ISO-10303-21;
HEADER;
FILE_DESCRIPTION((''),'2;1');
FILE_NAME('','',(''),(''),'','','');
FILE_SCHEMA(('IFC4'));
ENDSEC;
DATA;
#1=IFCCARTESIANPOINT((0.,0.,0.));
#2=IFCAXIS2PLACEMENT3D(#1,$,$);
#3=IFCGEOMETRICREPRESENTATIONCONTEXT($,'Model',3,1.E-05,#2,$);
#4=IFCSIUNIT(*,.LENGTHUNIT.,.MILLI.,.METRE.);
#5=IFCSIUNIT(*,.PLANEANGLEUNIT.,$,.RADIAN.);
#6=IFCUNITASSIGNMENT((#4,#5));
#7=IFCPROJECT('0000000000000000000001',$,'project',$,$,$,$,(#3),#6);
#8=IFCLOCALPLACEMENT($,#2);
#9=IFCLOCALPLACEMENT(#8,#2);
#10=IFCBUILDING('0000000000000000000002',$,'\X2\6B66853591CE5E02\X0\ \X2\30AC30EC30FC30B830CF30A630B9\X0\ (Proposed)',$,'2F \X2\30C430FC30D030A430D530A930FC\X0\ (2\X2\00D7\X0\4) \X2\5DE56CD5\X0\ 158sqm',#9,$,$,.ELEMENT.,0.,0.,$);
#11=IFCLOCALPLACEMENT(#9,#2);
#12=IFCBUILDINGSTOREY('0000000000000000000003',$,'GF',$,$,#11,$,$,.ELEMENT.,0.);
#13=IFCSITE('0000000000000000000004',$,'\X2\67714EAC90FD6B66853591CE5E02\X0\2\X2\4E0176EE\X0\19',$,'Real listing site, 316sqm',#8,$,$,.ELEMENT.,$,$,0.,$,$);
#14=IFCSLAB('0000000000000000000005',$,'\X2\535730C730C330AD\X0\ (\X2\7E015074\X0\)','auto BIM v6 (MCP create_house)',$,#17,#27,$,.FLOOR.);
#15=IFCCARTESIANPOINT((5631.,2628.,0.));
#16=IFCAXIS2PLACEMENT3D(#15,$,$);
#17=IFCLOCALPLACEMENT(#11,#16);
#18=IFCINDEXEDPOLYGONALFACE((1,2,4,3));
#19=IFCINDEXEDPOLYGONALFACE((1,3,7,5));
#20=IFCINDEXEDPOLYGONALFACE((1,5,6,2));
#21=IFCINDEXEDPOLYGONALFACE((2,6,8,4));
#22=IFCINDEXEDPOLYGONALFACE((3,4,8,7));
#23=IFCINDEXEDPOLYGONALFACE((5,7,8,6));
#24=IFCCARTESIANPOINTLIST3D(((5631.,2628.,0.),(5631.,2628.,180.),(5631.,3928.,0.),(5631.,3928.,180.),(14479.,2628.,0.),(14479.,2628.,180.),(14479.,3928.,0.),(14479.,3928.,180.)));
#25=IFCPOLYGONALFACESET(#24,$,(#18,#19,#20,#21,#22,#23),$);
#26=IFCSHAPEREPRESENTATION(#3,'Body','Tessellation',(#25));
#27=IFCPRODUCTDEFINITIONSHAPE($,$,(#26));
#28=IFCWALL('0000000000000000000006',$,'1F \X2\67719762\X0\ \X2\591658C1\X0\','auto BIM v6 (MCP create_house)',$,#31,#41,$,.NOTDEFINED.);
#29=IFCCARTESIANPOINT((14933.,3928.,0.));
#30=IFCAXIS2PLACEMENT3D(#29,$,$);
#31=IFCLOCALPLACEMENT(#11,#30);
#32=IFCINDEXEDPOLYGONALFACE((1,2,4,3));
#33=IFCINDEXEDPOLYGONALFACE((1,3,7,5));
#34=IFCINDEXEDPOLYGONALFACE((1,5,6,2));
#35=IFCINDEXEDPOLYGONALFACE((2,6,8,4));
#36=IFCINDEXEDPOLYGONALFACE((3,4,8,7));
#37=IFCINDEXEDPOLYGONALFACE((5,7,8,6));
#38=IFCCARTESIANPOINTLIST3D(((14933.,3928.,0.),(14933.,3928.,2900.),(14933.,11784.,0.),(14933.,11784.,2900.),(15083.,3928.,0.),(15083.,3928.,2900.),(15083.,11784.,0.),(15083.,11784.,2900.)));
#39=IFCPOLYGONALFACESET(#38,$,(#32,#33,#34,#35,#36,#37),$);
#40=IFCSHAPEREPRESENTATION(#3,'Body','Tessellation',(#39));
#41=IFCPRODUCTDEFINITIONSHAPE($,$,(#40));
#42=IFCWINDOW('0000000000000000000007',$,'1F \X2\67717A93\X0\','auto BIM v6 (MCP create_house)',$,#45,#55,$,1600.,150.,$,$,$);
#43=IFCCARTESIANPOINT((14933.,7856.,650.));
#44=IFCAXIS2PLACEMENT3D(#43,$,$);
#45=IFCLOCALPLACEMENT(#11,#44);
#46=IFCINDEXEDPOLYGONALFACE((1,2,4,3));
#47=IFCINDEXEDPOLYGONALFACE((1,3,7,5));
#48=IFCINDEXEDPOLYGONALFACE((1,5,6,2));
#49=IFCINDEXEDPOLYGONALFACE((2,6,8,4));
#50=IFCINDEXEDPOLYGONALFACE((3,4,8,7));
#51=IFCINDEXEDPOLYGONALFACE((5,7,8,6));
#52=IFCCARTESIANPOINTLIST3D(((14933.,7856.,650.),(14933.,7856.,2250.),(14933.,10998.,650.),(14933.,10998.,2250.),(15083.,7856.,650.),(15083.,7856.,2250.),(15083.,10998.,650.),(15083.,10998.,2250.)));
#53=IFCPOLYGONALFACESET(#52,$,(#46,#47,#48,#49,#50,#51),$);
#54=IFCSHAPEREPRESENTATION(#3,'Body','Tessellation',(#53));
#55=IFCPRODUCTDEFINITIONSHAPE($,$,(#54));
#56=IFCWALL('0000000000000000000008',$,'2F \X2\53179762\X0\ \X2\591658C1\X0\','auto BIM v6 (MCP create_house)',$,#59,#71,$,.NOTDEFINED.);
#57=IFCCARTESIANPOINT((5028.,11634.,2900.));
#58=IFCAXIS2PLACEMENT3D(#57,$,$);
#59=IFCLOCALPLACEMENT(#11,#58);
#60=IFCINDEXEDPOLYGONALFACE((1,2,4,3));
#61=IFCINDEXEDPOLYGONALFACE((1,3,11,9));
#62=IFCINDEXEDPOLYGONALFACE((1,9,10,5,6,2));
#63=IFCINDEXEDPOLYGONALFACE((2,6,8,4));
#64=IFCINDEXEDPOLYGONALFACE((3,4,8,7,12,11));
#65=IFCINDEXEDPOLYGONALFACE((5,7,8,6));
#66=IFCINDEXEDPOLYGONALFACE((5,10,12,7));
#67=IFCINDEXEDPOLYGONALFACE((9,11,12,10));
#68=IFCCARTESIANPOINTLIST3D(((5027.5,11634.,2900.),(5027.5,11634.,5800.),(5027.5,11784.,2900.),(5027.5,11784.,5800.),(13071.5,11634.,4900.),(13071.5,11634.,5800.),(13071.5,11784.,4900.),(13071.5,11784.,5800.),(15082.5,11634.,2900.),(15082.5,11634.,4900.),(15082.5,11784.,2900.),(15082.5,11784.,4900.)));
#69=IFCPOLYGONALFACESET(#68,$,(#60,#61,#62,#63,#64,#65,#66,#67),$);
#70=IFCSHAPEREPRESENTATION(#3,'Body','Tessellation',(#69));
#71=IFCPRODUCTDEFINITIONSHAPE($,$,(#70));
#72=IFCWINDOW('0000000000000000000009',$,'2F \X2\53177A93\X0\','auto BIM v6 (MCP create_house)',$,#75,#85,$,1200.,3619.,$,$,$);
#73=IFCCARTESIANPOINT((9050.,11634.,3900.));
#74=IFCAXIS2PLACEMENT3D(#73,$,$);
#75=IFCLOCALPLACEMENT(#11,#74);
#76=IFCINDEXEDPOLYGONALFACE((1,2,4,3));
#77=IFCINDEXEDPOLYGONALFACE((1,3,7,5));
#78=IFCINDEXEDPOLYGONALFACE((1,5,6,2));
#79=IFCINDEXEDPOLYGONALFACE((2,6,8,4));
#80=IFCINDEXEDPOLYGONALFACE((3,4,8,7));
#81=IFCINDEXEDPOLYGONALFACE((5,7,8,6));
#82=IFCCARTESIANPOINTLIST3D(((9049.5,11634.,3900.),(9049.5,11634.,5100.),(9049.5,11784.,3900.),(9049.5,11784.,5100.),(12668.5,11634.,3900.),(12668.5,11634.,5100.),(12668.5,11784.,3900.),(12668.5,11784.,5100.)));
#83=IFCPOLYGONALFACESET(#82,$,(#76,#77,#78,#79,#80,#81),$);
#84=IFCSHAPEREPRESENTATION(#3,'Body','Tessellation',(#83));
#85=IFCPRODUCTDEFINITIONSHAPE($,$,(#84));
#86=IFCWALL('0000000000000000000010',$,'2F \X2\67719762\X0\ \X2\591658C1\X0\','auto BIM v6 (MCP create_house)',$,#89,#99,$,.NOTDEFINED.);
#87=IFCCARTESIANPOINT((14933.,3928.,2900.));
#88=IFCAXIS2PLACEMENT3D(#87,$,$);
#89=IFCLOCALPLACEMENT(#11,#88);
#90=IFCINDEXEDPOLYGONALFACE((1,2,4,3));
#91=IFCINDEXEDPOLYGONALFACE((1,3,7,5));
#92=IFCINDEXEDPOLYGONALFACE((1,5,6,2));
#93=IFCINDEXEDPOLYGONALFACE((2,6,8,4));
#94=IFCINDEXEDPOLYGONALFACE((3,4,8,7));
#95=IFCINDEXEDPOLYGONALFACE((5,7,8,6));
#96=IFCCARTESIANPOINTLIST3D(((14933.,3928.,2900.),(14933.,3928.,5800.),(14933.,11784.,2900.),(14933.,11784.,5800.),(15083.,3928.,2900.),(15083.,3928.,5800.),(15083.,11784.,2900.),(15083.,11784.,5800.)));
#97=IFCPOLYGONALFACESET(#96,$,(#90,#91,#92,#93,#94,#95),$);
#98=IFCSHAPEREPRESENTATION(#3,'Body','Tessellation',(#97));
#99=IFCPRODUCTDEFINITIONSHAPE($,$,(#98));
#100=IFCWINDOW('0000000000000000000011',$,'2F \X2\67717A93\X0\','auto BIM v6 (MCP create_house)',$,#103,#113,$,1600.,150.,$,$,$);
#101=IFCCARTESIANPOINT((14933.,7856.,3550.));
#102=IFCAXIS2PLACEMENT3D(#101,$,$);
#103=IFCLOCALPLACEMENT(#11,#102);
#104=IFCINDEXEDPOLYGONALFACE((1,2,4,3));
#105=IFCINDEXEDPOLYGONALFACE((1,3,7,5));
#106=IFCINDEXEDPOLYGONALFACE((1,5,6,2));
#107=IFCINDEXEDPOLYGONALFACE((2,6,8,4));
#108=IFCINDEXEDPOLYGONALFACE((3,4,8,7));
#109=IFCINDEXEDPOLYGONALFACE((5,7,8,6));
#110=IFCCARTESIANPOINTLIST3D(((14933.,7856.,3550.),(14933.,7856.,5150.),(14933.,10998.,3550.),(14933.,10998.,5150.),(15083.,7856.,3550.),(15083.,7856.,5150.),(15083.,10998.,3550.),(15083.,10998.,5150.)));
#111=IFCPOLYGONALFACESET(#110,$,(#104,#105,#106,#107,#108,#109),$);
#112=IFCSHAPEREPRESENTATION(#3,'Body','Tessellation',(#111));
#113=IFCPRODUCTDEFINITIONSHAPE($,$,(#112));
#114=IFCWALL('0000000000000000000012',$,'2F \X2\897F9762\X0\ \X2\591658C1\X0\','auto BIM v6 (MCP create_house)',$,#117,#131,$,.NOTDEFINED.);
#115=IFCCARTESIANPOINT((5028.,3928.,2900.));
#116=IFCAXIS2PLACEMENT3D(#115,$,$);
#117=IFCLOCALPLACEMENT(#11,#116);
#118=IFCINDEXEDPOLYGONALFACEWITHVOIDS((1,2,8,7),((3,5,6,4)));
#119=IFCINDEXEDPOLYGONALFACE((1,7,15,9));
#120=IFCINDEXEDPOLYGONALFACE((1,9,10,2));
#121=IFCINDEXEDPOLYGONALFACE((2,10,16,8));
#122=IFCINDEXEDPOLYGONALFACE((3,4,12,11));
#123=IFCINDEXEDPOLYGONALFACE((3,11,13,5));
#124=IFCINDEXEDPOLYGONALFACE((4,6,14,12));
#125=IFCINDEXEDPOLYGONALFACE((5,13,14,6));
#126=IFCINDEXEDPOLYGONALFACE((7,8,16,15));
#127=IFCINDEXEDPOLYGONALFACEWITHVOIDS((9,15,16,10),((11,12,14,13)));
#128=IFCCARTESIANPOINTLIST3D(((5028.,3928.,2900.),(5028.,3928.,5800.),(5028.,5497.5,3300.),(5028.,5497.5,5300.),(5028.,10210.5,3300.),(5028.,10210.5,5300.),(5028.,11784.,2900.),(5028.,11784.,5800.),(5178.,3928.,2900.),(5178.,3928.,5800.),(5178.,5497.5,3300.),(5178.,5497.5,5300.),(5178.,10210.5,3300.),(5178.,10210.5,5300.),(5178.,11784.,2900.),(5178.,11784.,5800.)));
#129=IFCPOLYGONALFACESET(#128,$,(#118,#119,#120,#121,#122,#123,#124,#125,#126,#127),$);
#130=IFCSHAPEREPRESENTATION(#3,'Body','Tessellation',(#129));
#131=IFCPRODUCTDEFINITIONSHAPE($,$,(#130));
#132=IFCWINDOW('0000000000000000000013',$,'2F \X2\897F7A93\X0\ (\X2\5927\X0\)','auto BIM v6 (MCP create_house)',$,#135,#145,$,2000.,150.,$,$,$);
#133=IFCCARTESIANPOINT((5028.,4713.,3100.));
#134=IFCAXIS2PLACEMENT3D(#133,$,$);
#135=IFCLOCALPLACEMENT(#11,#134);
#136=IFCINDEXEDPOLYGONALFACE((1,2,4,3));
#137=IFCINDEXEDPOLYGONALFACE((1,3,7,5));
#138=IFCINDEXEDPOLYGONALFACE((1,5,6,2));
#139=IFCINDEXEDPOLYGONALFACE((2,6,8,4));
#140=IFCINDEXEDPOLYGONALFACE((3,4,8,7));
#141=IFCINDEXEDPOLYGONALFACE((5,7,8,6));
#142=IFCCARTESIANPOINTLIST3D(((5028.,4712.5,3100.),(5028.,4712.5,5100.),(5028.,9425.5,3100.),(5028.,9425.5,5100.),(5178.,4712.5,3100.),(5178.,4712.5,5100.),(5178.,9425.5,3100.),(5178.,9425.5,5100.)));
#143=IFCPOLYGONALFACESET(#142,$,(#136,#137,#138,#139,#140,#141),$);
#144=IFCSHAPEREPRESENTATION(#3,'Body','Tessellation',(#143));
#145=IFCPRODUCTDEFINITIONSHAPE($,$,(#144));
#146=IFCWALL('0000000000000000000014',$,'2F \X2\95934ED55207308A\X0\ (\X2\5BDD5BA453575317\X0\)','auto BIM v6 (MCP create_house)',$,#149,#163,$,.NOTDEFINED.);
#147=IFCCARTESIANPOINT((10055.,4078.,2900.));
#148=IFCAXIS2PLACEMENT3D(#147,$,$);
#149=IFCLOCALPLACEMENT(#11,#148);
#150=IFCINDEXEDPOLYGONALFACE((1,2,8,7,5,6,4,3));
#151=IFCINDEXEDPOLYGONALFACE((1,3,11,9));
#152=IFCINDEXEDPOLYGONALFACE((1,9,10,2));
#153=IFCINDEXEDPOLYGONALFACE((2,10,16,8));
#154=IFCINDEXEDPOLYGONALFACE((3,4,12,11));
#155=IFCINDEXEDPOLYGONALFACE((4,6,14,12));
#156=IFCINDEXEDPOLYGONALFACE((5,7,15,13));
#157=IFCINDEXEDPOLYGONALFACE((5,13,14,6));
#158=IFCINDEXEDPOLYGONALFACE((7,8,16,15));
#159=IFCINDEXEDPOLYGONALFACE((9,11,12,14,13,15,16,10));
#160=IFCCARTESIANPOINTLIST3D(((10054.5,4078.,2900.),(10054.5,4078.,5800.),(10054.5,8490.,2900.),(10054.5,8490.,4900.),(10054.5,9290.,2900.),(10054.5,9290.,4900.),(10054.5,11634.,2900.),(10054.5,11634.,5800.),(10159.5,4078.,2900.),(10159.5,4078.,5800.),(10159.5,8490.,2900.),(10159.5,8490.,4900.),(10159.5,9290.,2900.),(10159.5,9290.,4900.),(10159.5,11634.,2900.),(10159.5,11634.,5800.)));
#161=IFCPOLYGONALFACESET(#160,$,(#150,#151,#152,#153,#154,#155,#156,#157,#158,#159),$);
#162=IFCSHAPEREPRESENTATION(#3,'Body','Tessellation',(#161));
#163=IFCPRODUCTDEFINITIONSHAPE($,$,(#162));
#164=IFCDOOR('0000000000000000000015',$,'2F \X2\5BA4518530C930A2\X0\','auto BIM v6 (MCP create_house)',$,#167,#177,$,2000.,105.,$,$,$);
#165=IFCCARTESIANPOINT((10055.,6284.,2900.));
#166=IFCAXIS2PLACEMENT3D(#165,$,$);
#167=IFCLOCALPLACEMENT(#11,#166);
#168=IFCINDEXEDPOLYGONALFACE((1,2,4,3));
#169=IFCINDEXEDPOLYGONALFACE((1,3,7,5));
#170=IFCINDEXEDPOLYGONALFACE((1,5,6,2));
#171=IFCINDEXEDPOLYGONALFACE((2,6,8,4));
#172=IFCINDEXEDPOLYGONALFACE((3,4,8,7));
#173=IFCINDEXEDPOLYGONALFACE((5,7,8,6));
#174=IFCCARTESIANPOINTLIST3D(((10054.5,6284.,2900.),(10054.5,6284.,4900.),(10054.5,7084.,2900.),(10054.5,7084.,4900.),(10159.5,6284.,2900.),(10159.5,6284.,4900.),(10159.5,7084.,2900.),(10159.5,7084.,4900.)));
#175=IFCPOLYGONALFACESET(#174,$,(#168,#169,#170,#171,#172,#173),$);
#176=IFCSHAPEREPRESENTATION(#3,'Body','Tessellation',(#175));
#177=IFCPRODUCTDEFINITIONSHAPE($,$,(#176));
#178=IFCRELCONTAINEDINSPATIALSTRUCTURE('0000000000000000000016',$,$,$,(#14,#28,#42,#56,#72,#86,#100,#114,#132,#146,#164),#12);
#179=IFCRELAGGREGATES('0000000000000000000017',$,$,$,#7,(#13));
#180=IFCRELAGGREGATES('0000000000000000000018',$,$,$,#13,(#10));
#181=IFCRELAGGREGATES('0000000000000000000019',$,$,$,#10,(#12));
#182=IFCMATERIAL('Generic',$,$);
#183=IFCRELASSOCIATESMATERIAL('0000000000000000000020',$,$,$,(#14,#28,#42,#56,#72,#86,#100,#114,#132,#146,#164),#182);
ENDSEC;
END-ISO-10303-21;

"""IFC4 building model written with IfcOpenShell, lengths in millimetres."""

from ifc_helpers import new_model, si_unit, frame, frame_2d, origin, place, context, project, spatial, rectangle, extrude, material, element, fill, save


model = new_model("IFC4")

# Units and contexts
model_context = context("Model", 3, precision=1e-05, world=origin())
ifc_project = project(units=[si_unit("LENGTHUNIT", "METRE", prefix="MILLI"), si_unit("PLANEANGLEUNIT", "RADIAN")], contexts=[model_context])

# Site, building, storey
site_placement = place(None, origin())
site = spatial("IfcSite", under=ifc_project, at=site_placement, Name="東京都武蔵野市2丁目19", ObjectType="Real listing site, 316sqm", CompositionType="ELEMENT", RefElevation=0.0)
building_placement = place(site_placement, origin())
building = spatial("IfcBuilding", under=site, at=building_placement, Name="武蔵野市 ガレージハウス (Proposed)", ObjectType="2F ツーバイフォー (2×4) 工法 158sqm", CompositionType="ELEMENT", ElevationOfRefHeight=0.0, ElevationOfTerrain=0.0)
storey_placement = place(building_placement, origin())
storey = spatial("IfcBuildingStorey", under=building, at=storey_placement, Name="GF", CompositionType="ELEMENT", Elevation=0.0)

# Slab
ifc_material = material(Name="Generic")
slab_placement = place(storey_placement, frame((5631.0, 2628.0, 0.0)))
element("IfcSlab", 1, at=slab_placement, inside=storey, material=ifc_material, Name="南デッキ (縁側)", Description="auto BIM v6 (MCP create_house)", PredefinedType="FLOOR", context=model_context, shape_type="SweptSolid", body=[
    extrude(rectangle(XDim=8848.0, YDim=1300.0, at=frame_2d((4424.0, 650.0))), frame((5631.0, 2628.0, 0.0)), (0.0, 0.0, 1.0), 180.0),
])

# Wall, opening, window
wall_1_placement = place(storey_placement, frame((14933.0, 3928.0, 0.0)))
wall_1 = element("IfcWall", 2, at=wall_1_placement, inside=storey, material=ifc_material, Name="1F 東面 外壁", Description="auto BIM v6 (MCP create_house)", PredefinedType="NOTDEFINED", context=model_context, shape_type="SweptSolid", body=[
    extrude(rectangle(XDim=150.0, YDim=7856.0, at=frame_2d((75.0, 3928.0))), frame((14933.0, 3928.0, 0.0)), (0.0, 0.0, 1.0), 2900.0),
])
opening_1_placement = place(storey_placement, frame((14933.0, 7856.0, 650.0)))
opening_1 = element("IfcOpeningElement", 3, at=opening_1_placement, cuts=wall_1, PredefinedType="NOTDEFINED", context=model_context, shape_type="SweptSolid", body=[
    extrude(rectangle(XDim=150.0, YDim=3142.0, at=frame_2d((75.0, 1571.0))), frame((14933.0, 7856.0, 650.0)), (0.0, 0.0, 1.0), 1600.0),
])
window_1_placement = place(storey_placement, frame((14933.0, 7856.0, 650.0)))
window_1 = element("IfcWindow", 4, at=window_1_placement, inside=storey, material=ifc_material, Name="1F 東窓", Description="auto BIM v6 (MCP create_house)", OverallHeight=1600.0, OverallWidth=150.0, context=model_context, shape_type="SweptSolid", body=[
    extrude(rectangle(XDim=150.0, YDim=3142.0, at=frame_2d((75.0, 1571.0))), frame((14933.0, 7856.0, 650.0)), (0.0, 0.0, 1.0), 1600.0),
])
fill(opening_1, window_1)

# Walls, openings, windows
wall_2_placement = place(storey_placement, frame((5028.0, 11634.0, 2900.0)))
wall_2 = element("IfcWall", 5, at=wall_2_placement, inside=storey, material=ifc_material, Name="2F 北面 外壁", Description="auto BIM v6 (MCP create_house)", PredefinedType="NOTDEFINED", context=model_context, shape_type="SweptSolid", body=[
    extrude(rectangle(XDim=10055.0, YDim=150.0, at=frame_2d((5027.0, 75.0))), frame((5028.0, 11634.0, 2900.0)), (0.0, 0.0, 1.0), 2900.0),
])
opening_2_placement = place(storey_placement, frame((9050.0, 11634.0, 3900.0)))
opening_2 = element("IfcOpeningElement", 6, at=opening_2_placement, cuts=wall_2, PredefinedType="NOTDEFINED", context=model_context, shape_type="SweptSolid", body=[
    extrude(rectangle(XDim=3619.0, YDim=150.0, at=frame_2d((1809.0, 75.0))), frame((9050.0, 11634.0, 3900.0)), (0.0, 0.0, 1.0), 1200.0),
])
window_2_placement = place(storey_placement, frame((9050.0, 11634.0, 3900.0)))
window_2 = element("IfcWindow", 7, at=window_2_placement, inside=storey, material=ifc_material, Name="2F 北窓", Description="auto BIM v6 (MCP create_house)", OverallHeight=1200.0, OverallWidth=3619.0, context=model_context, shape_type="SweptSolid", body=[
    extrude(rectangle(XDim=3619.0, YDim=150.0, at=frame_2d((1809.0, 75.0))), frame((9050.0, 11634.0, 3900.0)), (0.0, 0.0, 1.0), 1200.0),
])
fill(opening_2, window_2)
wall_3_placement = place(storey_placement, frame((14933.0, 3928.0, 2900.0)))
wall_3 = element("IfcWall", 8, at=wall_3_placement, inside=storey, material=ifc_material, Name="2F 東面 外壁", Description="auto BIM v6 (MCP create_house)", PredefinedType="NOTDEFINED", context=model_context, shape_type="SweptSolid", body=[
    extrude(rectangle(XDim=150.0, YDim=7856.0, at=frame_2d((75.0, 3928.0))), frame((14933.0, 3928.0, 2900.0)), (0.0, 0.0, 1.0), 2900.0),
])
opening_3_placement = place(storey_placement, frame((14933.0, 7856.0, 3550.0)))
opening_3 = element("IfcOpeningElement", 9, at=opening_3_placement, cuts=wall_3, PredefinedType="NOTDEFINED", context=model_context, shape_type="SweptSolid", body=[
    extrude(rectangle(XDim=150.0, YDim=3142.0, at=frame_2d((75.0, 1571.0))), frame((14933.0, 7856.0, 3550.0)), (0.0, 0.0, 1.0), 1600.0),
])
window_3_placement = place(storey_placement, frame((14933.0, 7856.0, 3550.0)))
window_3 = element("IfcWindow", 10, at=window_3_placement, inside=storey, material=ifc_material, Name="2F 東窓", Description="auto BIM v6 (MCP create_house)", OverallHeight=1600.0, OverallWidth=150.0, context=model_context, shape_type="SweptSolid", body=[
    extrude(rectangle(XDim=150.0, YDim=3142.0, at=frame_2d((75.0, 1571.0))), frame((14933.0, 7856.0, 3550.0)), (0.0, 0.0, 1.0), 1600.0),
])
fill(opening_3, window_3)
wall_4_placement = place(storey_placement, frame((5028.0, 3928.0, 2900.0)))
wall_4 = element("IfcWall", 11, at=wall_4_placement, inside=storey, material=ifc_material, Name="2F 西面 外壁", Description="auto BIM v6 (MCP create_house)", PredefinedType="NOTDEFINED", context=model_context, shape_type="SweptSolid", body=[
    extrude(rectangle(XDim=150.0, YDim=7856.0, at=frame_2d((75.0, 3928.0))), frame((5028.0, 3928.0, 2900.0)), (0.0, 0.0, 1.0), 2900.0),
])
opening_4_placement = place(storey_placement, frame((5028.0, 4713.0, 3100.0)))
opening_4 = element("IfcOpeningElement", 12, at=opening_4_placement, cuts=wall_4, PredefinedType="NOTDEFINED", context=model_context, shape_type="SweptSolid", body=[
    extrude(rectangle(XDim=150.0, YDim=4713.0, at=frame_2d((75.0, 2356.0))), frame((5028.0, 4713.0, 3100.0)), (0.0, 0.0, 1.0), 2000.0),
])
window_4_placement = place(storey_placement, frame((5028.0, 4713.0, 3100.0)))
window_4 = element("IfcWindow", 13, at=window_4_placement, inside=storey, material=ifc_material, Name="2F 西窓 (大)", Description="auto BIM v6 (MCP create_house)", OverallHeight=2000.0, OverallWidth=150.0, context=model_context, shape_type="SweptSolid", body=[
    extrude(rectangle(XDim=150.0, YDim=4713.0, at=frame_2d((75.0, 2356.0))), frame((5028.0, 4713.0, 3100.0)), (0.0, 0.0, 1.0), 2000.0),
])
fill(opening_4, window_4)

# Wall, opening, door
wall_5_placement = place(storey_placement, frame((10055.0, 4078.0, 2900.0)))
wall_5 = element("IfcWall", 14, at=wall_5_placement, inside=storey, material=ifc_material, Name="2F 間仕切り (寝室南北)", Description="auto BIM v6 (MCP create_house)", PredefinedType="NOTDEFINED", context=model_context, shape_type="SweptSolid", body=[
    extrude(rectangle(XDim=105.0, YDim=7556.0, at=frame_2d((52.0, 3778.0))), frame((10055.0, 4078.0, 2900.0)), (0.0, 0.0, 1.0), 2900.0),
])
opening_5_placement = place(storey_placement, frame((10055.0, 6284.0, 2900.0)))
opening_5 = element("IfcOpeningElement", 15, at=opening_5_placement, cuts=wall_5, PredefinedType="NOTDEFINED", context=model_context, shape_type="SweptSolid", body=[
    extrude(rectangle(XDim=105.0, YDim=800.0, at=frame_2d((52.0, 400.0))), frame((10055.0, 6284.0, 2900.0)), (0.0, 0.0, 1.0), 2000.0),
])
door_placement = place(storey_placement, frame((10055.0, 6284.0, 2900.0)))
door = element("IfcDoor", 16, at=door_placement, inside=storey, material=ifc_material, Name="2F 室内ドア", Description="auto BIM v6 (MCP create_house)", OverallHeight=2000.0, OverallWidth=105.0, context=model_context, shape_type="SweptSolid", body=[
    extrude(rectangle(XDim=105.0, YDim=800.0, at=frame_2d((52.0, 400.0))), frame((10055.0, 6284.0, 2900.0)), (0.0, 0.0, 1.0), 2000.0),
])
fill(opening_5, door)

save(model, "model.ifc")
